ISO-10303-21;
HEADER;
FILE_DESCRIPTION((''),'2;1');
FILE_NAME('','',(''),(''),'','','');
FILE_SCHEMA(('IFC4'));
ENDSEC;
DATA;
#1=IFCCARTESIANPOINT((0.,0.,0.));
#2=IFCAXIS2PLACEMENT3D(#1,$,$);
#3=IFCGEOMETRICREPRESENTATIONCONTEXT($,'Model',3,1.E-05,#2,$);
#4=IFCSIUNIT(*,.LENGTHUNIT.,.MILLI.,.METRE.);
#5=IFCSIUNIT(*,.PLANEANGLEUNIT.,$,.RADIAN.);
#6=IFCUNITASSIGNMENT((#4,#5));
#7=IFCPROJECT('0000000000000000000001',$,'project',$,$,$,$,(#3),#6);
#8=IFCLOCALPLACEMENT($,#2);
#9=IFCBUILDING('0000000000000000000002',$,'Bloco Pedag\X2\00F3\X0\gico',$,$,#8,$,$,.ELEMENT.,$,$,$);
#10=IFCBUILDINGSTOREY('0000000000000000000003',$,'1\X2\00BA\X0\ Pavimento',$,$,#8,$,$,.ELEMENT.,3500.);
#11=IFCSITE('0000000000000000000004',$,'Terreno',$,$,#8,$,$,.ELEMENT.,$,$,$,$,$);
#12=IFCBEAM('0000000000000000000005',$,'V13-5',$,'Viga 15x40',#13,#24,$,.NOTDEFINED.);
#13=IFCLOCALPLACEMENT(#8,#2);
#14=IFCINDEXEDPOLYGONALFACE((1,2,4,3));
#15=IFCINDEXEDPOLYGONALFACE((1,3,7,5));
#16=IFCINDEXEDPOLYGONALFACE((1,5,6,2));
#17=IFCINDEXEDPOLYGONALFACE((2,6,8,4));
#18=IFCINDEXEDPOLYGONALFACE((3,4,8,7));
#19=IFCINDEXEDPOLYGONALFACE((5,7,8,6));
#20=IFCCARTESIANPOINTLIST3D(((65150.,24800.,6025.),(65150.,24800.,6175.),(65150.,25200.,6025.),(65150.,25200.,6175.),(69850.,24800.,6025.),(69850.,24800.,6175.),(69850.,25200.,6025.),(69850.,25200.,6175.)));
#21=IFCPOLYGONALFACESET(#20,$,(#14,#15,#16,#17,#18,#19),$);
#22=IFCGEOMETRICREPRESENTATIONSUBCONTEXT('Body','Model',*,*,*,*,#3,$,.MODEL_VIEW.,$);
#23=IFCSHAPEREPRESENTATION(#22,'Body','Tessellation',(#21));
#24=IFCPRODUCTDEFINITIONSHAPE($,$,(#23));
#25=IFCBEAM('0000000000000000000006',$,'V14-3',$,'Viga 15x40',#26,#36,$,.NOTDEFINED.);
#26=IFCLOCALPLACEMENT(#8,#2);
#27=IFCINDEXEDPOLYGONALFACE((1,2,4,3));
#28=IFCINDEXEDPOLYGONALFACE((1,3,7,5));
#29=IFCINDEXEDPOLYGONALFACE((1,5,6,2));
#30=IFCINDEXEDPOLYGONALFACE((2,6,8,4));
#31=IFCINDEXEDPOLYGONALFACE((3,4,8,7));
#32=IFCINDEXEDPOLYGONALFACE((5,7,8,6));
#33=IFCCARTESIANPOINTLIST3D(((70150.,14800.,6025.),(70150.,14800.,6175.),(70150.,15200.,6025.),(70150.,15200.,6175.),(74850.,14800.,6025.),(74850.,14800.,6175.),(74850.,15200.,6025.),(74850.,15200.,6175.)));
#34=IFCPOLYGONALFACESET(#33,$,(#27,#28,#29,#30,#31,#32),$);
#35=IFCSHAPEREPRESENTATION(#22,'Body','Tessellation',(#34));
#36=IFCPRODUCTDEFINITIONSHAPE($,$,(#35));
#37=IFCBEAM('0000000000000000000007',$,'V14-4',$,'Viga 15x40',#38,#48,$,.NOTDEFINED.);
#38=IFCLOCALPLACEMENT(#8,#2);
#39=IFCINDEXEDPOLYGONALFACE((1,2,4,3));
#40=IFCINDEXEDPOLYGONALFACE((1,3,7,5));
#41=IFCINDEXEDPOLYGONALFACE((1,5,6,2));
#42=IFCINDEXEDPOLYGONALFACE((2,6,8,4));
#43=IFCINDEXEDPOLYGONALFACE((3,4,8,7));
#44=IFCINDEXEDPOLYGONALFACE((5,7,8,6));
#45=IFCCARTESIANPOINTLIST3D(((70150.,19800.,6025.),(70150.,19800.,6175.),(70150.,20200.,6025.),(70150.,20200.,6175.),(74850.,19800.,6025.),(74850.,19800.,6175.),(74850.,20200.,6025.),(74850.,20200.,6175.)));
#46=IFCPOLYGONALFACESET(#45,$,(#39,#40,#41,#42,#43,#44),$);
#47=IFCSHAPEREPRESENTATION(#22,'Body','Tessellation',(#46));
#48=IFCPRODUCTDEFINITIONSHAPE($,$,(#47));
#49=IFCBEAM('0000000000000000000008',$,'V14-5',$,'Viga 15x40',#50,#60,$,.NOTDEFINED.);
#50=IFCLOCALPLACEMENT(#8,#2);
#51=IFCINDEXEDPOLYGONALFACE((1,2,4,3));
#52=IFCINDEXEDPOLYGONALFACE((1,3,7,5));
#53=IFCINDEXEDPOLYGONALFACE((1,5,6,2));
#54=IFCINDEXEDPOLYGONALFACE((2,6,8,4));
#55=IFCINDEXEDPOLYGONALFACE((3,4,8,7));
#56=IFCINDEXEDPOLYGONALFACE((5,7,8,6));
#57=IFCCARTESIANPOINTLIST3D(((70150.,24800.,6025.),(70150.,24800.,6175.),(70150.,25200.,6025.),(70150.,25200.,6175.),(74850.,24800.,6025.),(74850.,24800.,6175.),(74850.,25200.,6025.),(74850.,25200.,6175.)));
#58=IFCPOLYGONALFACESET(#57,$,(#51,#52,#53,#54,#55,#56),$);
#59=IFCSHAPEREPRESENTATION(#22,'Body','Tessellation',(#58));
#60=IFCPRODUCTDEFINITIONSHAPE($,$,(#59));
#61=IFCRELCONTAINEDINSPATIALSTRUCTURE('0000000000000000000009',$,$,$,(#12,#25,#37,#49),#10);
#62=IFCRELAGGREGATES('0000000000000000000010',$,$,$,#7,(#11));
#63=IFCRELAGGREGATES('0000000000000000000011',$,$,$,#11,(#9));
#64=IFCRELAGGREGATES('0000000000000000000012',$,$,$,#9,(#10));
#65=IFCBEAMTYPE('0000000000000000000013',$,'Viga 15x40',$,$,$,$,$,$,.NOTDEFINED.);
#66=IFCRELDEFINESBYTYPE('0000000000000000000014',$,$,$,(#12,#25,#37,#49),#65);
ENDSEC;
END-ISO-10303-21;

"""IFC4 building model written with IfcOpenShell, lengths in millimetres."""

from ifc_helpers import new_model, si_unit, frame, origin, origin_2d, place, context, subcontext, project, spatial, rectangle, extrude, type_object, element, save


model = new_model("IFC4")

# Units and contexts
model_context = context("Model", 3, precision=1e-05, world=origin())
body_context = subcontext(model_context, "Body", "Model", "MODEL_VIEW")
ifc_project = project(units=[si_unit("LENGTHUNIT", "METRE", prefix="MILLI"), si_unit("PLANEANGLEUNIT", "RADIAN")], contexts=[model_context])

# Site, building, storey
placement = place(None, origin())
site = spatial("IfcSite", under=ifc_project, at=placement, Name="Terreno", CompositionType="ELEMENT")
building = spatial("IfcBuilding", under=site, at=placement, Name="Bloco Pedagógico", CompositionType="ELEMENT")
storey = spatial("IfcBuildingStorey", under=building, at=placement, Name="1º Pavimento", CompositionType="ELEMENT", Elevation=3500.0)

# Beams
beam_type = type_object("IfcBeamType", Name="Viga 15x40", PredefinedType="NOTDEFINED")
for number, where, z_axis, x_axis, name in (
    (1, (65150.0, 25000.0, 6100.0), (1.0, 0.0, 0.0), (0.0, 1.0, 0.0), "V13-5"),
    (2, (70150.0, 15000.0, 6100.0), (1.0, 0.0, 0.0), (0.0, 1.0, 0.0), "V14-3"),
    (3, (70150.0, 20000.0, 6100.0), (1.0, 0.0, 0.0), (0.0, 1.0, 0.0), "V14-4"),
    (4, (70150.0, 25000.0, 6100.0), (1.0, 0.0, 0.0), (0.0, 1.0, 0.0), "V14-5"),
):
    element("IfcBeam", number, at=place(None, frame(where, z_axis=z_axis, x_axis=x_axis)), inside=storey, type_object=beam_type, Name=name, ObjectType="Viga 15x40", PredefinedType="NOTDEFINED", context=body_context, shape_type="SweptSolid", body=[
        extrude(rectangle(XDim=400.0, YDim=150.0, at=origin_2d()), None, (0.0, 0.0, 1.0), 4700.0),
    ])

save(model, "model.ifc")
